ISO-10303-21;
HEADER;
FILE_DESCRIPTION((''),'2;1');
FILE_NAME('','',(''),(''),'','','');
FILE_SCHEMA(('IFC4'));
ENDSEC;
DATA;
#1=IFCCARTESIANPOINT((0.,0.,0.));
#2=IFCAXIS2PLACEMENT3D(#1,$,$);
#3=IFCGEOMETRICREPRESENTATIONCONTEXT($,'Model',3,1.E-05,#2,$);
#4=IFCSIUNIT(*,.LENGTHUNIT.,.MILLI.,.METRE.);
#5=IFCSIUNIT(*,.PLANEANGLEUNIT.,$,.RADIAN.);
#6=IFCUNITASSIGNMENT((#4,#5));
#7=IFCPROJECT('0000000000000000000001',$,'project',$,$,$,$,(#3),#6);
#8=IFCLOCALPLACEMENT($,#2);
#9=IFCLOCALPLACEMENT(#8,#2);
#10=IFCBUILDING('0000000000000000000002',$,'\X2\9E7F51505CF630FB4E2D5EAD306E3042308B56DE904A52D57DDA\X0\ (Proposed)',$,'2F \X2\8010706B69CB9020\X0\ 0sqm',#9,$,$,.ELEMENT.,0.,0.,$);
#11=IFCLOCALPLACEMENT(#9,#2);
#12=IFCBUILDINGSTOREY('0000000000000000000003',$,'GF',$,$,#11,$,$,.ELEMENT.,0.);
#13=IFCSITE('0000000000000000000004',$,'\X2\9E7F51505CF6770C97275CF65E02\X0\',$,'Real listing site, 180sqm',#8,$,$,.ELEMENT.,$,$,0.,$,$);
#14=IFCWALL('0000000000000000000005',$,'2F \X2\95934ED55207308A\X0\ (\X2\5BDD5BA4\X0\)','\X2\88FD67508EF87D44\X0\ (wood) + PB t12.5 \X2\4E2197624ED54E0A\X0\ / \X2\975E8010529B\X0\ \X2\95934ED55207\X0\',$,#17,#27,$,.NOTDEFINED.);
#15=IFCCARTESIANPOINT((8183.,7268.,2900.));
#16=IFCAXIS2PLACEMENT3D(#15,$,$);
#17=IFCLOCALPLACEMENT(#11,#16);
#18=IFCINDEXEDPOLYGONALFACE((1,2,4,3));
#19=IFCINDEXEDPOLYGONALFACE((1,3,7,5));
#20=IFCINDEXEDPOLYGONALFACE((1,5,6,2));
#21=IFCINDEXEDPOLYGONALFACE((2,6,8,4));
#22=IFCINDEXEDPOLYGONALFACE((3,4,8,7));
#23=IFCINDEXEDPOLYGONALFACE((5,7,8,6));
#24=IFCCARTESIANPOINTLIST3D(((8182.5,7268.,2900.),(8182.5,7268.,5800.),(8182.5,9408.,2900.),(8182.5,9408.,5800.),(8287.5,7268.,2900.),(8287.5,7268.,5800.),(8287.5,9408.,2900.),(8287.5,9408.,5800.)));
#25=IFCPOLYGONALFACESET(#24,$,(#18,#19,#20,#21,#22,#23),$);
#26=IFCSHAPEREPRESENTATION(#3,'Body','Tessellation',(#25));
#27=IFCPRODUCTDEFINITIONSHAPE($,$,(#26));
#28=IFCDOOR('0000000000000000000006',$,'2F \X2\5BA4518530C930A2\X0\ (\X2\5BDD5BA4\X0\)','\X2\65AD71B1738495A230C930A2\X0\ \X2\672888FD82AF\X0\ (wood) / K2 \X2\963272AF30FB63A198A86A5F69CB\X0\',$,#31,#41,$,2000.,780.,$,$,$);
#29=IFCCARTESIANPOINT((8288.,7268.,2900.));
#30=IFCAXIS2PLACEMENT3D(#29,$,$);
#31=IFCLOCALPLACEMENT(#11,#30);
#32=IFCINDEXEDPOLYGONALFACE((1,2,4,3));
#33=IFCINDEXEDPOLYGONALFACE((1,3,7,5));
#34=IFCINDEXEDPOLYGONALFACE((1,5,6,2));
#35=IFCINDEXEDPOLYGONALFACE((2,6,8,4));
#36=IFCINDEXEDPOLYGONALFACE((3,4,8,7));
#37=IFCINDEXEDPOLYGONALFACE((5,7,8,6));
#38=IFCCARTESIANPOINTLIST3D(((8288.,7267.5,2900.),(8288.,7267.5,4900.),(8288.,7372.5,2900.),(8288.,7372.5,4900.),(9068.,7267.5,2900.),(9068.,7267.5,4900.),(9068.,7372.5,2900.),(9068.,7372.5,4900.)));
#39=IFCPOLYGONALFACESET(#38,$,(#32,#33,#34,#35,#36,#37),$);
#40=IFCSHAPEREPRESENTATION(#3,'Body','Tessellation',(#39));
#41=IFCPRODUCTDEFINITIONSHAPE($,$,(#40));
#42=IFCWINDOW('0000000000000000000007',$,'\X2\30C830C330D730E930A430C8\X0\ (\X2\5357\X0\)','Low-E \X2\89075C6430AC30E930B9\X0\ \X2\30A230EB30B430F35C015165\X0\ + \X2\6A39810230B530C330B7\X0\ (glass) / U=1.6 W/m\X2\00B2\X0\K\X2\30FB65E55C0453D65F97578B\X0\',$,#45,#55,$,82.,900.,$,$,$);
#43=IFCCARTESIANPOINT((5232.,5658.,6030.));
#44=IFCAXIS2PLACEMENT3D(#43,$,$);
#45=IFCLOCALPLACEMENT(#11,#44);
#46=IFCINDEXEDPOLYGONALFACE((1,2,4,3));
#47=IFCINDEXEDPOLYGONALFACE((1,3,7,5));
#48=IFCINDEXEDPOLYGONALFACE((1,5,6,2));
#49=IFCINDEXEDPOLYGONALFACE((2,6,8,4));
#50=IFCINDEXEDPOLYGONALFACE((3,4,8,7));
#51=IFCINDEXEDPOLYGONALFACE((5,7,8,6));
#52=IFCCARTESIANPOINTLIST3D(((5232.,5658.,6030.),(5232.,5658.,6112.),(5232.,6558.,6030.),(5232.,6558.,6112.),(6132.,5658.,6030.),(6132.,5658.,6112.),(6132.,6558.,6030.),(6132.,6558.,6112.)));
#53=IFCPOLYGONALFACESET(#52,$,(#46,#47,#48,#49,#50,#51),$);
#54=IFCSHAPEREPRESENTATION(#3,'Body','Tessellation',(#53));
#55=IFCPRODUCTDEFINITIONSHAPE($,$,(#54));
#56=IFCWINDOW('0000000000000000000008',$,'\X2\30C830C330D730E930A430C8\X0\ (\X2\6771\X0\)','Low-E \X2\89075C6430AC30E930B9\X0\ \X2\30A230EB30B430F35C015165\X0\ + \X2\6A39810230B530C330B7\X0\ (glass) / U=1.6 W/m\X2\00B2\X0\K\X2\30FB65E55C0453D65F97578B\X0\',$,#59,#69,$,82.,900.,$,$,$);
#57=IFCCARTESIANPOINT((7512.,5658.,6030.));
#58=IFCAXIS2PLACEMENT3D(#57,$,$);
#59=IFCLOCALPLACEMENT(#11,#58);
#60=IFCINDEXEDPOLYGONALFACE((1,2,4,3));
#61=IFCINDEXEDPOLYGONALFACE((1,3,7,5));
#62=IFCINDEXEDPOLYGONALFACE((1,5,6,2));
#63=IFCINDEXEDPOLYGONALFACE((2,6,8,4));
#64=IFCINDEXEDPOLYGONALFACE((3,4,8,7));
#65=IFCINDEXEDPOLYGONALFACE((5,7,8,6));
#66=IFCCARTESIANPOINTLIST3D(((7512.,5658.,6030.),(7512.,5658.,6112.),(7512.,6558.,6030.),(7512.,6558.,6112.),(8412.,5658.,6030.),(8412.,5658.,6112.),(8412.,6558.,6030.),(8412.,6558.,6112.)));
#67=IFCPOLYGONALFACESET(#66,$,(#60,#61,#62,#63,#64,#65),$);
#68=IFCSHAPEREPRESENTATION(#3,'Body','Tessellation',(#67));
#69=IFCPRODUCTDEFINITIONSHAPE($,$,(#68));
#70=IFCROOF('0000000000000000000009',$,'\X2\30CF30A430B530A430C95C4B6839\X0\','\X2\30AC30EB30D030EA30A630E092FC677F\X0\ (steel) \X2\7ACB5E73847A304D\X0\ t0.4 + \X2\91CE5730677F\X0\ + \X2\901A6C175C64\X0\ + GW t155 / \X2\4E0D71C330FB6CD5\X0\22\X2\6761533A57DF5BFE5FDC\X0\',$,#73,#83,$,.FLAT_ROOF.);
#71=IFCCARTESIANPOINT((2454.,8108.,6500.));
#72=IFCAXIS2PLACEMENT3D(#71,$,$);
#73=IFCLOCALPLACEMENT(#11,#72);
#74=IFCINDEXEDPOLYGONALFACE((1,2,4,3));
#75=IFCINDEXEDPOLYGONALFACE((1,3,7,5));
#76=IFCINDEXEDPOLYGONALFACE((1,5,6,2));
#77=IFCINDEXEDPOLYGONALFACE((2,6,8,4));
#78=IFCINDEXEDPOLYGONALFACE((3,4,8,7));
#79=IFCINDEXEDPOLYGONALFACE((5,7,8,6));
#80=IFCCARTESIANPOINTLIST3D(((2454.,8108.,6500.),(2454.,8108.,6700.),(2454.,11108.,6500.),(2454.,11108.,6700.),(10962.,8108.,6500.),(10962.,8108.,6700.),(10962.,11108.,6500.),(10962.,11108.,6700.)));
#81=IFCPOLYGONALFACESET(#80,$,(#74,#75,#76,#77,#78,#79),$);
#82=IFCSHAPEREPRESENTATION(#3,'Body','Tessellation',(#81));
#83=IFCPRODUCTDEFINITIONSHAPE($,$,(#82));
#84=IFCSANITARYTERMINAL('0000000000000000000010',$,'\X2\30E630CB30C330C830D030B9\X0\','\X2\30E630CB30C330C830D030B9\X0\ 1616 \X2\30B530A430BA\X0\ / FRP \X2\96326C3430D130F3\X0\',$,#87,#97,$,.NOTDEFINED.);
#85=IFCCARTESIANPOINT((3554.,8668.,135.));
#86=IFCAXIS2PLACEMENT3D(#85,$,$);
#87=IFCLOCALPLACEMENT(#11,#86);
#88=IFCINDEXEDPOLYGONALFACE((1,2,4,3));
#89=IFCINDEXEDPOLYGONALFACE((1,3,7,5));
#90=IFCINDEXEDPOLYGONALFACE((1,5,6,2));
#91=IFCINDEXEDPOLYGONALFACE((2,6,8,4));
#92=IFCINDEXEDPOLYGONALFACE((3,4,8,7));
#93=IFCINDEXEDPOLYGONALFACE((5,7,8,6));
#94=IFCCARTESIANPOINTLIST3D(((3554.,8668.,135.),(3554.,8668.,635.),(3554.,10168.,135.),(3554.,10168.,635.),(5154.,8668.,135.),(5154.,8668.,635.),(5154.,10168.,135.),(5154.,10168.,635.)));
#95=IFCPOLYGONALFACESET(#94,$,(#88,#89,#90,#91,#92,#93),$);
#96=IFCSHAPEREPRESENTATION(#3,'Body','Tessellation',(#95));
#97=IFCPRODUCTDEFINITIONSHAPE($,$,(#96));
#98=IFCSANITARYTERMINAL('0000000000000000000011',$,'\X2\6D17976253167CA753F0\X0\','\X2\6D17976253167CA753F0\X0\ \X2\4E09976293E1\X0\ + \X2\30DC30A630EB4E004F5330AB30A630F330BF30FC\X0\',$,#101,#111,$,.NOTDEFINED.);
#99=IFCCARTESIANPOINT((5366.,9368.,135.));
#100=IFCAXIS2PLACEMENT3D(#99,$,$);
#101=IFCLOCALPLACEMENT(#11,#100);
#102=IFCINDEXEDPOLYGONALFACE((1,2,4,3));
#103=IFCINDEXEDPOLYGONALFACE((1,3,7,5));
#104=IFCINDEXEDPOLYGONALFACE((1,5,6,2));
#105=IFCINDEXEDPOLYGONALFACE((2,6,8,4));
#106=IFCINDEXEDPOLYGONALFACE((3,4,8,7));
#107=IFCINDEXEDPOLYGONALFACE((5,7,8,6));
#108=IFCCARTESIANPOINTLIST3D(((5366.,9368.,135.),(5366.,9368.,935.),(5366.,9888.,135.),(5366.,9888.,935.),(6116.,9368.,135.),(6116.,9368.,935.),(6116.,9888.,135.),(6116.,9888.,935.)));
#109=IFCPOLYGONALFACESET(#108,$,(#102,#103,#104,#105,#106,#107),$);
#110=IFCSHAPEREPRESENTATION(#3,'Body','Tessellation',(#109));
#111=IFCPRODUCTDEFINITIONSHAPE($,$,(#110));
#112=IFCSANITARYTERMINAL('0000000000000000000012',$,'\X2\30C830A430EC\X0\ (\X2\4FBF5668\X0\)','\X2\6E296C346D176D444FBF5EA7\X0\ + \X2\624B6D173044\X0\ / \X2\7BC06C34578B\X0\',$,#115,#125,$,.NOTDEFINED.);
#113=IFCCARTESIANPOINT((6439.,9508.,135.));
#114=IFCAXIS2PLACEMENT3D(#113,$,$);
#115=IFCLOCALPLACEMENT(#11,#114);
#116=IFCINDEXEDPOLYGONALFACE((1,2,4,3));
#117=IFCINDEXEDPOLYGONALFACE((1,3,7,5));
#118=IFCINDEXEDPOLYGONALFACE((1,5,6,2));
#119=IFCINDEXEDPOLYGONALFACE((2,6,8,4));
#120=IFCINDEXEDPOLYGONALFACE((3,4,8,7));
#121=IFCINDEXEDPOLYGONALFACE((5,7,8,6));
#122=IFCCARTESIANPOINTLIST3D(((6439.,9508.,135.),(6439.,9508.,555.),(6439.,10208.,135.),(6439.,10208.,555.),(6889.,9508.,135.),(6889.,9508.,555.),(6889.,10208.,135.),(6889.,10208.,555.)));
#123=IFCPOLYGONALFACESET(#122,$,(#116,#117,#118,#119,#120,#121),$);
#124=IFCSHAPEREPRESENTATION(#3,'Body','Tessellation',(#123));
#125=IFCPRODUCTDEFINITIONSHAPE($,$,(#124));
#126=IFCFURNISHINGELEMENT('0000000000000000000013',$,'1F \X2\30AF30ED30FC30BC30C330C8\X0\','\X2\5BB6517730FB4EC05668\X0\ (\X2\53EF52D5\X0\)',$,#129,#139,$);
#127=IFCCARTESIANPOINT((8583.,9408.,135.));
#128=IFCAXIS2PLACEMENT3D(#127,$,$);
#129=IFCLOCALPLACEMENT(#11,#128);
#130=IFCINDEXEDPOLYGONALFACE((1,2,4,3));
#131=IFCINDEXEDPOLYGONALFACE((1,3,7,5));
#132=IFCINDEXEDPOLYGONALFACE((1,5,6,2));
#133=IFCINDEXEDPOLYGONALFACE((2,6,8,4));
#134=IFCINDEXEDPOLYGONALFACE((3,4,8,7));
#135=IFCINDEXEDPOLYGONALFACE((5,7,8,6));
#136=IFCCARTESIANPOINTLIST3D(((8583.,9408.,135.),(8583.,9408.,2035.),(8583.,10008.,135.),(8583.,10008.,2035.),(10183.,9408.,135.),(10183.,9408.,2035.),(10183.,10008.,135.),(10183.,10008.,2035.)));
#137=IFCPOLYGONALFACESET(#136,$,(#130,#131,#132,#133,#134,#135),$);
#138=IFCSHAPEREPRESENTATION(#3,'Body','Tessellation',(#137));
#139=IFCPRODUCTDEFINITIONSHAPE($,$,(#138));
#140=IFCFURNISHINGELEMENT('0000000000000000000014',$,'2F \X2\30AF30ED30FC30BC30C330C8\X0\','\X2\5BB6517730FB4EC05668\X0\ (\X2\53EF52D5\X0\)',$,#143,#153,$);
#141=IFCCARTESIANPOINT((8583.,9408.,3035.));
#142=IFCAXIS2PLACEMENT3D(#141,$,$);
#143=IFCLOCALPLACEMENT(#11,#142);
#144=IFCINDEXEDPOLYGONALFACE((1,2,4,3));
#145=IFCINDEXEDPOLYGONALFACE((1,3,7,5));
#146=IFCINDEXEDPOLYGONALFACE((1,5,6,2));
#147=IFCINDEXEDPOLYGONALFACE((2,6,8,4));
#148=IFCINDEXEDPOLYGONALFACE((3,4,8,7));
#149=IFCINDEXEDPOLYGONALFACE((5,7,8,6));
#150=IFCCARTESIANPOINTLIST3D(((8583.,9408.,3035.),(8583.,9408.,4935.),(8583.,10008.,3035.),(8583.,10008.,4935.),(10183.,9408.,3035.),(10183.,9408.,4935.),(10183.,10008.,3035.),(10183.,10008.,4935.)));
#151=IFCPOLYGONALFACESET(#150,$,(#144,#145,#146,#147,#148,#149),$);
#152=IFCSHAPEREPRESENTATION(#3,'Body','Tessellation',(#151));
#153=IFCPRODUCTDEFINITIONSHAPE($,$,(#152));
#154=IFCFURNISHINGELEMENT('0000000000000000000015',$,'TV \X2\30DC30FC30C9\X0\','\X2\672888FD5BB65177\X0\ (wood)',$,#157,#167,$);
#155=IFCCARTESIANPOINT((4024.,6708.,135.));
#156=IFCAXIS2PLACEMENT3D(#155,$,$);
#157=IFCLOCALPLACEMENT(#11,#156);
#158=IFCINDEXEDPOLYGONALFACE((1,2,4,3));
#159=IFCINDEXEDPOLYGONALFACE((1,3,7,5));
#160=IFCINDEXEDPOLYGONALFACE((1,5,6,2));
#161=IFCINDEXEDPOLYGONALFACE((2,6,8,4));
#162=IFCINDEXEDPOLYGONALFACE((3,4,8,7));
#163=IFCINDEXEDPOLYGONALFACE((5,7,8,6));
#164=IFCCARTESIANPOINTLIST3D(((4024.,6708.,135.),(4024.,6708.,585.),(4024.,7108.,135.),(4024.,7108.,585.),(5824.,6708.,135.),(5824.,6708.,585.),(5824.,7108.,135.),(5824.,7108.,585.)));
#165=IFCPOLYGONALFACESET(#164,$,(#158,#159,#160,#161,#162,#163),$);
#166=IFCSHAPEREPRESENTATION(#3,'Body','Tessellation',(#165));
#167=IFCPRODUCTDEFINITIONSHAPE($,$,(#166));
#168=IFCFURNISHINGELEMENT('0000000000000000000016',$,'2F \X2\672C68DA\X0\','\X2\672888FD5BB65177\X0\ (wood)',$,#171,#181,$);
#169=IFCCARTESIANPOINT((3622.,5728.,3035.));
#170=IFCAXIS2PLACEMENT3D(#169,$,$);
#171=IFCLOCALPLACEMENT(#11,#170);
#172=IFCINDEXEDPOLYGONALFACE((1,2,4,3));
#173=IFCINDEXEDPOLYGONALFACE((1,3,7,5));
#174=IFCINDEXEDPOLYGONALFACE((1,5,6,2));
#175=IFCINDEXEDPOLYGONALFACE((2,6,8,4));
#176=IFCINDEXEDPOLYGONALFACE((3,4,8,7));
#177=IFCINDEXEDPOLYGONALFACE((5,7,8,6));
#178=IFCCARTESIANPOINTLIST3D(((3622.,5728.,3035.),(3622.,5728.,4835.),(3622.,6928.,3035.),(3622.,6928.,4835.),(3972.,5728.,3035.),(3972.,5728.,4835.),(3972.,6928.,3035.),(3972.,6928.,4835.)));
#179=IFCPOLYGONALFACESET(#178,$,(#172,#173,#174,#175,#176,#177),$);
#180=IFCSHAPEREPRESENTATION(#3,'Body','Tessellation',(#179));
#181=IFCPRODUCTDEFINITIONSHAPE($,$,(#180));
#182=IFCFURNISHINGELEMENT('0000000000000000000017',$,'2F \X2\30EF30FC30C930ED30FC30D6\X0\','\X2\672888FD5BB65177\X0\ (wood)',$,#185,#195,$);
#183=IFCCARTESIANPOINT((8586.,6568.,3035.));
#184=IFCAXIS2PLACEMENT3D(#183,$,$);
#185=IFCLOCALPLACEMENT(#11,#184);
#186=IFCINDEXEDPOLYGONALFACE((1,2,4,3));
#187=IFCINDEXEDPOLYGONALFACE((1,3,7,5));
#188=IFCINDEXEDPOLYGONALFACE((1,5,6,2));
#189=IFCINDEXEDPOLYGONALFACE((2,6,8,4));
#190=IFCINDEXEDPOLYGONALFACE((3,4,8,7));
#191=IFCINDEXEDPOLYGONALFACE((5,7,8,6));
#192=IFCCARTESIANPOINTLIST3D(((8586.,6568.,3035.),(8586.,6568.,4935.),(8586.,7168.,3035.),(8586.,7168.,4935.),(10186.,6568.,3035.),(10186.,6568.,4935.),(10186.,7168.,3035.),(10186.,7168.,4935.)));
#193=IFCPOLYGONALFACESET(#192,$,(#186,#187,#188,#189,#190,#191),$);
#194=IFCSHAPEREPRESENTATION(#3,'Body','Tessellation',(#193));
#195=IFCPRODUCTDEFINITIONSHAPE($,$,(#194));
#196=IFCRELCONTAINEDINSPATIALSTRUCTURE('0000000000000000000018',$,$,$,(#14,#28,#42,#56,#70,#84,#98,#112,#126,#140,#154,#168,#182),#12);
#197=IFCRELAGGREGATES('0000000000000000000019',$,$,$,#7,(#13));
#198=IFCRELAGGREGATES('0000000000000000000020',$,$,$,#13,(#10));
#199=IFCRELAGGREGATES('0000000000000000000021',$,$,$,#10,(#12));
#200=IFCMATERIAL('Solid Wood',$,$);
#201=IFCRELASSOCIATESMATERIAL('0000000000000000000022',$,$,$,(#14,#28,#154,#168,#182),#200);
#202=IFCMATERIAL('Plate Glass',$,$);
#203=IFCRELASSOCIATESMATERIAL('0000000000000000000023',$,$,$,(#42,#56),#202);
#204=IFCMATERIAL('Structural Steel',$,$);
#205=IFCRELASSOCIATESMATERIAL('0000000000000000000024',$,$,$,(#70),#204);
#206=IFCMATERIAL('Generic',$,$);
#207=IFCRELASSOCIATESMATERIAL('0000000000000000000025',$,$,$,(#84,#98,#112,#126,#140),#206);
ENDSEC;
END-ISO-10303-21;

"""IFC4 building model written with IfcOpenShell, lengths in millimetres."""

from ifc_helpers import new_model, si_unit, frame, frame_2d, origin, place, context, project, spatial, rectangle, extrude, material, element, save


model = new_model("IFC4")

# Units and contexts
model_context = context("Model", 3, precision=1e-05, world=origin())
ifc_project = project(units=[si_unit("LENGTHUNIT", "METRE", prefix="MILLI"), si_unit("PLANEANGLEUNIT", "RADIAN")], contexts=[model_context])

# Site, building, storey
site_placement = place(None, origin())
site = spatial("IfcSite", under=ifc_project, at=site_placement, Name="鹿児島県霧島市", ObjectType="Real listing site, 180sqm", CompositionType="ELEMENT", RefElevation=0.0)
building_placement = place(site_placement, origin())
building = spatial("IfcBuilding", under=site, at=building_placement, Name="鹿児島・中庭のある回遊動線 (Proposed)", ObjectType="2F 耐火構造 0sqm", CompositionType="ELEMENT", ElevationOfRefHeight=0.0, ElevationOfTerrain=0.0)
storey_placement = place(building_placement, origin())
storey = spatial("IfcBuildingStorey", under=building, at=storey_placement, Name="GF", CompositionType="ELEMENT", Elevation=0.0)

# Shared definitions
ifc_material_1 = material(Name="Solid Wood")
ifc_material_2 = material(Name="Plate Glass")

# Wall
wall_1_placement = place(storey_placement, frame((8183.0, 7268.0, 2900.0)))
element("IfcWall", 1, at=wall_1_placement, inside=storey, material=ifc_material_1, Name="2F 間仕切り (寝室)", Description="製材軸組 (wood) + PB t12.5 両面仕上 / 非耐力 間仕切", PredefinedType="NOTDEFINED", context=model_context, shape_type="SweptSolid", body=[
    extrude(rectangle(XDim=105.0, YDim=2140.0, at=frame_2d((52.0, 1070.0))), frame((8183.0, 7268.0, 2900.0)), (0.0, 0.0, 1.0), 2900.0),
])

# Door
door_1_placement = place(storey_placement, frame((8288.0, 7268.0, 2900.0)))
element("IfcDoor", 2, at=door_1_placement, inside=storey, material=ifc_material_1, Name="2F 室内ドア (寝室)", Description="断熱玄関ドア 木製芯 (wood) / K2 防犯・採風機構", OverallHeight=2000.0, OverallWidth=780.0, context=model_context, shape_type="SweptSolid", body=[
    extrude(rectangle(XDim=780.0, YDim=105.0, at=frame_2d((390.0, 52.0))), frame((8288.0, 7268.0, 2900.0)), (0.0, 0.0, 1.0), 2000.0),
])

# Windows
window_1_placement = place(storey_placement, frame((5232.0, 5658.0, 6030.0)))
element("IfcWindow", 3, at=window_1_placement, inside=storey, material=ifc_material_2, Name="トップライト (南)", Description="Low-E 複層ガラス アルゴン封入 + 樹脂サッシ (glass) / U=1.6 W/m²K・日射取得型", OverallHeight=82.0, OverallWidth=900.0, context=model_context, shape_type="SweptSolid", body=[
    extrude(rectangle(XDim=900.0, YDim=900.0, at=frame_2d((450.0, 450.0))), frame((5232.0, 5658.0, 6030.0)), (0.0, 0.0, 1.0), 82.0),
])
window_2_placement = place(storey_placement, frame((7512.0, 5658.0, 6030.0)))
element("IfcWindow", 4, at=window_2_placement, inside=storey, material=ifc_material_2, Name="トップライト (東)", Description="Low-E 複層ガラス アルゴン封入 + 樹脂サッシ (glass) / U=1.6 W/m²K・日射取得型", OverallHeight=82.0, OverallWidth=900.0, context=model_context, shape_type="SweptSolid", body=[
    extrude(rectangle(XDim=900.0, YDim=900.0, at=frame_2d((450.0, 450.0))), frame((7512.0, 5658.0, 6030.0)), (0.0, 0.0, 1.0), 82.0),
])

# Roof
ifc_material_3 = material(Name="Structural Steel")
roof_placement = place(storey_placement, frame((2454.0, 8108.0, 6500.0)))
element("IfcRoof", 5, at=roof_placement, inside=storey, material=ifc_material_3, Name="ハイサイド屋根", Description="ガルバリウム鋼板 (steel) 立平葺き t0.4 + 野地板 + 通気層 + GW t155 / 不燃・法22条区域対応", PredefinedType="FLAT_ROOF", context=model_context, shape_type="SweptSolid", body=[
    extrude(rectangle(XDim=8508.0, YDim=3000.0, at=frame_2d((4254.0, 1500.0))), frame((2454.0, 8108.0, 6500.0)), (0.0, 0.0, 1.0), 200.0),
])

# Sanitary terminals
ifc_material_4 = material(Name="Generic")
sanitary_terminal_1_placement = place(storey_placement, frame((3554.0, 8668.0, 135.0)))
element("IfcSanitaryTerminal", 6, at=sanitary_terminal_1_placement, inside=storey, material=ifc_material_4, Name="ユニットバス", Description="ユニットバス 1616 サイズ / FRP 防水パン", PredefinedType="NOTDEFINED", context=model_context, shape_type="SweptSolid", body=[
    extrude(rectangle(XDim=1600.0, YDim=1500.0, at=frame_2d((800.0, 750.0))), frame((3554.0, 8668.0, 135.0)), (0.0, 0.0, 1.0), 500.0),
])
sanitary_terminal_2_placement = place(storey_placement, frame((5366.0, 9368.0, 135.0)))
element("IfcSanitaryTerminal", 7, at=sanitary_terminal_2_placement, inside=storey, material=ifc_material_4, Name="洗面化粧台", Description="洗面化粧台 三面鏡 + ボウル一体カウンター", PredefinedType="NOTDEFINED", context=model_context, shape_type="SweptSolid", body=[
    extrude(rectangle(XDim=750.0, YDim=520.0, at=frame_2d((375.0, 260.0))), frame((5366.0, 9368.0, 135.0)), (0.0, 0.0, 1.0), 800.0),
])
sanitary_terminal_3_placement = place(storey_placement, frame((6439.0, 9508.0, 135.0)))
element("IfcSanitaryTerminal", 8, at=sanitary_terminal_3_placement, inside=storey, material=ifc_material_4, Name="トイレ (便器)", Description="温水洗浄便座 + 手洗い / 節水型", PredefinedType="NOTDEFINED", context=model_context, shape_type="SweptSolid", body=[
    extrude(rectangle(XDim=450.0, YDim=700.0, at=frame_2d((225.0, 350.0))), frame((6439.0, 9508.0, 135.0)), (0.0, 0.0, 1.0), 420.0),
])

# Furnishing elements
furnishing_1_placement = place(storey_placement, frame((8583.0, 9408.0, 135.0)))
element("IfcFurnishingElement", 9, at=furnishing_1_placement, inside=storey, material=ifc_material_4, Name="1F クローゼット", Description="家具・什器 (可動)", context=model_context, shape_type="SweptSolid", body=[
    extrude(rectangle(XDim=1600.0, YDim=600.0, at=frame_2d((800.0, 300.0))), frame((8583.0, 9408.0, 135.0)), (0.0, 0.0, 1.0), 1900.0),
])
furnishing_2_placement = place(storey_placement, frame((8583.0, 9408.0, 3035.0)))
element("IfcFurnishingElement", 10, at=furnishing_2_placement, inside=storey, material=ifc_material_4, Name="2F クローゼット", Description="家具・什器 (可動)", context=model_context, shape_type="SweptSolid", body=[
    extrude(rectangle(XDim=1600.0, YDim=600.0, at=frame_2d((800.0, 300.0))), frame((8583.0, 9408.0, 3035.0)), (0.0, 0.0, 1.0), 1900.0),
])
furnishing_3_placement = place(storey_placement, frame((4024.0, 6708.0, 135.0)))
element("IfcFurnishingElement", 11, at=furnishing_3_placement, inside=storey, material=ifc_material_1, Name="TV ボード", Description="木製家具 (wood)", context=model_context, shape_type="SweptSolid", body=[
    extrude(rectangle(XDim=1800.0, YDim=400.0, at=frame_2d((900.0, 200.0))), frame((4024.0, 6708.0, 135.0)), (0.0, 0.0, 1.0), 450.0),
])
furnishing_4_placement = place(storey_placement, frame((3622.0, 5728.0, 3035.0)))
element("IfcFurnishingElement", 12, at=furnishing_4_placement, inside=storey, material=ifc_material_1, Name="2F 本棚", Description="木製家具 (wood)", context=model_context, shape_type="SweptSolid", body=[
    extrude(rectangle(XDim=350.0, YDim=1200.0, at=frame_2d((175.0, 600.0))), frame((3622.0, 5728.0, 3035.0)), (0.0, 0.0, 1.0), 1800.0),
])
furnishing_5_placement = place(storey_placement, frame((8586.0, 6568.0, 3035.0)))
element("IfcFurnishingElement", 13, at=furnishing_5_placement, inside=storey, material=ifc_material_1, Name="2F ワードローブ", Description="木製家具 (wood)", context=model_context, shape_type="SweptSolid", body=[
    extrude(rectangle(XDim=1600.0, YDim=600.0, at=frame_2d((800.0, 300.0))), frame((8586.0, 6568.0, 3035.0)), (0.0, 0.0, 1.0), 1900.0),
])

save(model, "model.ifc")
